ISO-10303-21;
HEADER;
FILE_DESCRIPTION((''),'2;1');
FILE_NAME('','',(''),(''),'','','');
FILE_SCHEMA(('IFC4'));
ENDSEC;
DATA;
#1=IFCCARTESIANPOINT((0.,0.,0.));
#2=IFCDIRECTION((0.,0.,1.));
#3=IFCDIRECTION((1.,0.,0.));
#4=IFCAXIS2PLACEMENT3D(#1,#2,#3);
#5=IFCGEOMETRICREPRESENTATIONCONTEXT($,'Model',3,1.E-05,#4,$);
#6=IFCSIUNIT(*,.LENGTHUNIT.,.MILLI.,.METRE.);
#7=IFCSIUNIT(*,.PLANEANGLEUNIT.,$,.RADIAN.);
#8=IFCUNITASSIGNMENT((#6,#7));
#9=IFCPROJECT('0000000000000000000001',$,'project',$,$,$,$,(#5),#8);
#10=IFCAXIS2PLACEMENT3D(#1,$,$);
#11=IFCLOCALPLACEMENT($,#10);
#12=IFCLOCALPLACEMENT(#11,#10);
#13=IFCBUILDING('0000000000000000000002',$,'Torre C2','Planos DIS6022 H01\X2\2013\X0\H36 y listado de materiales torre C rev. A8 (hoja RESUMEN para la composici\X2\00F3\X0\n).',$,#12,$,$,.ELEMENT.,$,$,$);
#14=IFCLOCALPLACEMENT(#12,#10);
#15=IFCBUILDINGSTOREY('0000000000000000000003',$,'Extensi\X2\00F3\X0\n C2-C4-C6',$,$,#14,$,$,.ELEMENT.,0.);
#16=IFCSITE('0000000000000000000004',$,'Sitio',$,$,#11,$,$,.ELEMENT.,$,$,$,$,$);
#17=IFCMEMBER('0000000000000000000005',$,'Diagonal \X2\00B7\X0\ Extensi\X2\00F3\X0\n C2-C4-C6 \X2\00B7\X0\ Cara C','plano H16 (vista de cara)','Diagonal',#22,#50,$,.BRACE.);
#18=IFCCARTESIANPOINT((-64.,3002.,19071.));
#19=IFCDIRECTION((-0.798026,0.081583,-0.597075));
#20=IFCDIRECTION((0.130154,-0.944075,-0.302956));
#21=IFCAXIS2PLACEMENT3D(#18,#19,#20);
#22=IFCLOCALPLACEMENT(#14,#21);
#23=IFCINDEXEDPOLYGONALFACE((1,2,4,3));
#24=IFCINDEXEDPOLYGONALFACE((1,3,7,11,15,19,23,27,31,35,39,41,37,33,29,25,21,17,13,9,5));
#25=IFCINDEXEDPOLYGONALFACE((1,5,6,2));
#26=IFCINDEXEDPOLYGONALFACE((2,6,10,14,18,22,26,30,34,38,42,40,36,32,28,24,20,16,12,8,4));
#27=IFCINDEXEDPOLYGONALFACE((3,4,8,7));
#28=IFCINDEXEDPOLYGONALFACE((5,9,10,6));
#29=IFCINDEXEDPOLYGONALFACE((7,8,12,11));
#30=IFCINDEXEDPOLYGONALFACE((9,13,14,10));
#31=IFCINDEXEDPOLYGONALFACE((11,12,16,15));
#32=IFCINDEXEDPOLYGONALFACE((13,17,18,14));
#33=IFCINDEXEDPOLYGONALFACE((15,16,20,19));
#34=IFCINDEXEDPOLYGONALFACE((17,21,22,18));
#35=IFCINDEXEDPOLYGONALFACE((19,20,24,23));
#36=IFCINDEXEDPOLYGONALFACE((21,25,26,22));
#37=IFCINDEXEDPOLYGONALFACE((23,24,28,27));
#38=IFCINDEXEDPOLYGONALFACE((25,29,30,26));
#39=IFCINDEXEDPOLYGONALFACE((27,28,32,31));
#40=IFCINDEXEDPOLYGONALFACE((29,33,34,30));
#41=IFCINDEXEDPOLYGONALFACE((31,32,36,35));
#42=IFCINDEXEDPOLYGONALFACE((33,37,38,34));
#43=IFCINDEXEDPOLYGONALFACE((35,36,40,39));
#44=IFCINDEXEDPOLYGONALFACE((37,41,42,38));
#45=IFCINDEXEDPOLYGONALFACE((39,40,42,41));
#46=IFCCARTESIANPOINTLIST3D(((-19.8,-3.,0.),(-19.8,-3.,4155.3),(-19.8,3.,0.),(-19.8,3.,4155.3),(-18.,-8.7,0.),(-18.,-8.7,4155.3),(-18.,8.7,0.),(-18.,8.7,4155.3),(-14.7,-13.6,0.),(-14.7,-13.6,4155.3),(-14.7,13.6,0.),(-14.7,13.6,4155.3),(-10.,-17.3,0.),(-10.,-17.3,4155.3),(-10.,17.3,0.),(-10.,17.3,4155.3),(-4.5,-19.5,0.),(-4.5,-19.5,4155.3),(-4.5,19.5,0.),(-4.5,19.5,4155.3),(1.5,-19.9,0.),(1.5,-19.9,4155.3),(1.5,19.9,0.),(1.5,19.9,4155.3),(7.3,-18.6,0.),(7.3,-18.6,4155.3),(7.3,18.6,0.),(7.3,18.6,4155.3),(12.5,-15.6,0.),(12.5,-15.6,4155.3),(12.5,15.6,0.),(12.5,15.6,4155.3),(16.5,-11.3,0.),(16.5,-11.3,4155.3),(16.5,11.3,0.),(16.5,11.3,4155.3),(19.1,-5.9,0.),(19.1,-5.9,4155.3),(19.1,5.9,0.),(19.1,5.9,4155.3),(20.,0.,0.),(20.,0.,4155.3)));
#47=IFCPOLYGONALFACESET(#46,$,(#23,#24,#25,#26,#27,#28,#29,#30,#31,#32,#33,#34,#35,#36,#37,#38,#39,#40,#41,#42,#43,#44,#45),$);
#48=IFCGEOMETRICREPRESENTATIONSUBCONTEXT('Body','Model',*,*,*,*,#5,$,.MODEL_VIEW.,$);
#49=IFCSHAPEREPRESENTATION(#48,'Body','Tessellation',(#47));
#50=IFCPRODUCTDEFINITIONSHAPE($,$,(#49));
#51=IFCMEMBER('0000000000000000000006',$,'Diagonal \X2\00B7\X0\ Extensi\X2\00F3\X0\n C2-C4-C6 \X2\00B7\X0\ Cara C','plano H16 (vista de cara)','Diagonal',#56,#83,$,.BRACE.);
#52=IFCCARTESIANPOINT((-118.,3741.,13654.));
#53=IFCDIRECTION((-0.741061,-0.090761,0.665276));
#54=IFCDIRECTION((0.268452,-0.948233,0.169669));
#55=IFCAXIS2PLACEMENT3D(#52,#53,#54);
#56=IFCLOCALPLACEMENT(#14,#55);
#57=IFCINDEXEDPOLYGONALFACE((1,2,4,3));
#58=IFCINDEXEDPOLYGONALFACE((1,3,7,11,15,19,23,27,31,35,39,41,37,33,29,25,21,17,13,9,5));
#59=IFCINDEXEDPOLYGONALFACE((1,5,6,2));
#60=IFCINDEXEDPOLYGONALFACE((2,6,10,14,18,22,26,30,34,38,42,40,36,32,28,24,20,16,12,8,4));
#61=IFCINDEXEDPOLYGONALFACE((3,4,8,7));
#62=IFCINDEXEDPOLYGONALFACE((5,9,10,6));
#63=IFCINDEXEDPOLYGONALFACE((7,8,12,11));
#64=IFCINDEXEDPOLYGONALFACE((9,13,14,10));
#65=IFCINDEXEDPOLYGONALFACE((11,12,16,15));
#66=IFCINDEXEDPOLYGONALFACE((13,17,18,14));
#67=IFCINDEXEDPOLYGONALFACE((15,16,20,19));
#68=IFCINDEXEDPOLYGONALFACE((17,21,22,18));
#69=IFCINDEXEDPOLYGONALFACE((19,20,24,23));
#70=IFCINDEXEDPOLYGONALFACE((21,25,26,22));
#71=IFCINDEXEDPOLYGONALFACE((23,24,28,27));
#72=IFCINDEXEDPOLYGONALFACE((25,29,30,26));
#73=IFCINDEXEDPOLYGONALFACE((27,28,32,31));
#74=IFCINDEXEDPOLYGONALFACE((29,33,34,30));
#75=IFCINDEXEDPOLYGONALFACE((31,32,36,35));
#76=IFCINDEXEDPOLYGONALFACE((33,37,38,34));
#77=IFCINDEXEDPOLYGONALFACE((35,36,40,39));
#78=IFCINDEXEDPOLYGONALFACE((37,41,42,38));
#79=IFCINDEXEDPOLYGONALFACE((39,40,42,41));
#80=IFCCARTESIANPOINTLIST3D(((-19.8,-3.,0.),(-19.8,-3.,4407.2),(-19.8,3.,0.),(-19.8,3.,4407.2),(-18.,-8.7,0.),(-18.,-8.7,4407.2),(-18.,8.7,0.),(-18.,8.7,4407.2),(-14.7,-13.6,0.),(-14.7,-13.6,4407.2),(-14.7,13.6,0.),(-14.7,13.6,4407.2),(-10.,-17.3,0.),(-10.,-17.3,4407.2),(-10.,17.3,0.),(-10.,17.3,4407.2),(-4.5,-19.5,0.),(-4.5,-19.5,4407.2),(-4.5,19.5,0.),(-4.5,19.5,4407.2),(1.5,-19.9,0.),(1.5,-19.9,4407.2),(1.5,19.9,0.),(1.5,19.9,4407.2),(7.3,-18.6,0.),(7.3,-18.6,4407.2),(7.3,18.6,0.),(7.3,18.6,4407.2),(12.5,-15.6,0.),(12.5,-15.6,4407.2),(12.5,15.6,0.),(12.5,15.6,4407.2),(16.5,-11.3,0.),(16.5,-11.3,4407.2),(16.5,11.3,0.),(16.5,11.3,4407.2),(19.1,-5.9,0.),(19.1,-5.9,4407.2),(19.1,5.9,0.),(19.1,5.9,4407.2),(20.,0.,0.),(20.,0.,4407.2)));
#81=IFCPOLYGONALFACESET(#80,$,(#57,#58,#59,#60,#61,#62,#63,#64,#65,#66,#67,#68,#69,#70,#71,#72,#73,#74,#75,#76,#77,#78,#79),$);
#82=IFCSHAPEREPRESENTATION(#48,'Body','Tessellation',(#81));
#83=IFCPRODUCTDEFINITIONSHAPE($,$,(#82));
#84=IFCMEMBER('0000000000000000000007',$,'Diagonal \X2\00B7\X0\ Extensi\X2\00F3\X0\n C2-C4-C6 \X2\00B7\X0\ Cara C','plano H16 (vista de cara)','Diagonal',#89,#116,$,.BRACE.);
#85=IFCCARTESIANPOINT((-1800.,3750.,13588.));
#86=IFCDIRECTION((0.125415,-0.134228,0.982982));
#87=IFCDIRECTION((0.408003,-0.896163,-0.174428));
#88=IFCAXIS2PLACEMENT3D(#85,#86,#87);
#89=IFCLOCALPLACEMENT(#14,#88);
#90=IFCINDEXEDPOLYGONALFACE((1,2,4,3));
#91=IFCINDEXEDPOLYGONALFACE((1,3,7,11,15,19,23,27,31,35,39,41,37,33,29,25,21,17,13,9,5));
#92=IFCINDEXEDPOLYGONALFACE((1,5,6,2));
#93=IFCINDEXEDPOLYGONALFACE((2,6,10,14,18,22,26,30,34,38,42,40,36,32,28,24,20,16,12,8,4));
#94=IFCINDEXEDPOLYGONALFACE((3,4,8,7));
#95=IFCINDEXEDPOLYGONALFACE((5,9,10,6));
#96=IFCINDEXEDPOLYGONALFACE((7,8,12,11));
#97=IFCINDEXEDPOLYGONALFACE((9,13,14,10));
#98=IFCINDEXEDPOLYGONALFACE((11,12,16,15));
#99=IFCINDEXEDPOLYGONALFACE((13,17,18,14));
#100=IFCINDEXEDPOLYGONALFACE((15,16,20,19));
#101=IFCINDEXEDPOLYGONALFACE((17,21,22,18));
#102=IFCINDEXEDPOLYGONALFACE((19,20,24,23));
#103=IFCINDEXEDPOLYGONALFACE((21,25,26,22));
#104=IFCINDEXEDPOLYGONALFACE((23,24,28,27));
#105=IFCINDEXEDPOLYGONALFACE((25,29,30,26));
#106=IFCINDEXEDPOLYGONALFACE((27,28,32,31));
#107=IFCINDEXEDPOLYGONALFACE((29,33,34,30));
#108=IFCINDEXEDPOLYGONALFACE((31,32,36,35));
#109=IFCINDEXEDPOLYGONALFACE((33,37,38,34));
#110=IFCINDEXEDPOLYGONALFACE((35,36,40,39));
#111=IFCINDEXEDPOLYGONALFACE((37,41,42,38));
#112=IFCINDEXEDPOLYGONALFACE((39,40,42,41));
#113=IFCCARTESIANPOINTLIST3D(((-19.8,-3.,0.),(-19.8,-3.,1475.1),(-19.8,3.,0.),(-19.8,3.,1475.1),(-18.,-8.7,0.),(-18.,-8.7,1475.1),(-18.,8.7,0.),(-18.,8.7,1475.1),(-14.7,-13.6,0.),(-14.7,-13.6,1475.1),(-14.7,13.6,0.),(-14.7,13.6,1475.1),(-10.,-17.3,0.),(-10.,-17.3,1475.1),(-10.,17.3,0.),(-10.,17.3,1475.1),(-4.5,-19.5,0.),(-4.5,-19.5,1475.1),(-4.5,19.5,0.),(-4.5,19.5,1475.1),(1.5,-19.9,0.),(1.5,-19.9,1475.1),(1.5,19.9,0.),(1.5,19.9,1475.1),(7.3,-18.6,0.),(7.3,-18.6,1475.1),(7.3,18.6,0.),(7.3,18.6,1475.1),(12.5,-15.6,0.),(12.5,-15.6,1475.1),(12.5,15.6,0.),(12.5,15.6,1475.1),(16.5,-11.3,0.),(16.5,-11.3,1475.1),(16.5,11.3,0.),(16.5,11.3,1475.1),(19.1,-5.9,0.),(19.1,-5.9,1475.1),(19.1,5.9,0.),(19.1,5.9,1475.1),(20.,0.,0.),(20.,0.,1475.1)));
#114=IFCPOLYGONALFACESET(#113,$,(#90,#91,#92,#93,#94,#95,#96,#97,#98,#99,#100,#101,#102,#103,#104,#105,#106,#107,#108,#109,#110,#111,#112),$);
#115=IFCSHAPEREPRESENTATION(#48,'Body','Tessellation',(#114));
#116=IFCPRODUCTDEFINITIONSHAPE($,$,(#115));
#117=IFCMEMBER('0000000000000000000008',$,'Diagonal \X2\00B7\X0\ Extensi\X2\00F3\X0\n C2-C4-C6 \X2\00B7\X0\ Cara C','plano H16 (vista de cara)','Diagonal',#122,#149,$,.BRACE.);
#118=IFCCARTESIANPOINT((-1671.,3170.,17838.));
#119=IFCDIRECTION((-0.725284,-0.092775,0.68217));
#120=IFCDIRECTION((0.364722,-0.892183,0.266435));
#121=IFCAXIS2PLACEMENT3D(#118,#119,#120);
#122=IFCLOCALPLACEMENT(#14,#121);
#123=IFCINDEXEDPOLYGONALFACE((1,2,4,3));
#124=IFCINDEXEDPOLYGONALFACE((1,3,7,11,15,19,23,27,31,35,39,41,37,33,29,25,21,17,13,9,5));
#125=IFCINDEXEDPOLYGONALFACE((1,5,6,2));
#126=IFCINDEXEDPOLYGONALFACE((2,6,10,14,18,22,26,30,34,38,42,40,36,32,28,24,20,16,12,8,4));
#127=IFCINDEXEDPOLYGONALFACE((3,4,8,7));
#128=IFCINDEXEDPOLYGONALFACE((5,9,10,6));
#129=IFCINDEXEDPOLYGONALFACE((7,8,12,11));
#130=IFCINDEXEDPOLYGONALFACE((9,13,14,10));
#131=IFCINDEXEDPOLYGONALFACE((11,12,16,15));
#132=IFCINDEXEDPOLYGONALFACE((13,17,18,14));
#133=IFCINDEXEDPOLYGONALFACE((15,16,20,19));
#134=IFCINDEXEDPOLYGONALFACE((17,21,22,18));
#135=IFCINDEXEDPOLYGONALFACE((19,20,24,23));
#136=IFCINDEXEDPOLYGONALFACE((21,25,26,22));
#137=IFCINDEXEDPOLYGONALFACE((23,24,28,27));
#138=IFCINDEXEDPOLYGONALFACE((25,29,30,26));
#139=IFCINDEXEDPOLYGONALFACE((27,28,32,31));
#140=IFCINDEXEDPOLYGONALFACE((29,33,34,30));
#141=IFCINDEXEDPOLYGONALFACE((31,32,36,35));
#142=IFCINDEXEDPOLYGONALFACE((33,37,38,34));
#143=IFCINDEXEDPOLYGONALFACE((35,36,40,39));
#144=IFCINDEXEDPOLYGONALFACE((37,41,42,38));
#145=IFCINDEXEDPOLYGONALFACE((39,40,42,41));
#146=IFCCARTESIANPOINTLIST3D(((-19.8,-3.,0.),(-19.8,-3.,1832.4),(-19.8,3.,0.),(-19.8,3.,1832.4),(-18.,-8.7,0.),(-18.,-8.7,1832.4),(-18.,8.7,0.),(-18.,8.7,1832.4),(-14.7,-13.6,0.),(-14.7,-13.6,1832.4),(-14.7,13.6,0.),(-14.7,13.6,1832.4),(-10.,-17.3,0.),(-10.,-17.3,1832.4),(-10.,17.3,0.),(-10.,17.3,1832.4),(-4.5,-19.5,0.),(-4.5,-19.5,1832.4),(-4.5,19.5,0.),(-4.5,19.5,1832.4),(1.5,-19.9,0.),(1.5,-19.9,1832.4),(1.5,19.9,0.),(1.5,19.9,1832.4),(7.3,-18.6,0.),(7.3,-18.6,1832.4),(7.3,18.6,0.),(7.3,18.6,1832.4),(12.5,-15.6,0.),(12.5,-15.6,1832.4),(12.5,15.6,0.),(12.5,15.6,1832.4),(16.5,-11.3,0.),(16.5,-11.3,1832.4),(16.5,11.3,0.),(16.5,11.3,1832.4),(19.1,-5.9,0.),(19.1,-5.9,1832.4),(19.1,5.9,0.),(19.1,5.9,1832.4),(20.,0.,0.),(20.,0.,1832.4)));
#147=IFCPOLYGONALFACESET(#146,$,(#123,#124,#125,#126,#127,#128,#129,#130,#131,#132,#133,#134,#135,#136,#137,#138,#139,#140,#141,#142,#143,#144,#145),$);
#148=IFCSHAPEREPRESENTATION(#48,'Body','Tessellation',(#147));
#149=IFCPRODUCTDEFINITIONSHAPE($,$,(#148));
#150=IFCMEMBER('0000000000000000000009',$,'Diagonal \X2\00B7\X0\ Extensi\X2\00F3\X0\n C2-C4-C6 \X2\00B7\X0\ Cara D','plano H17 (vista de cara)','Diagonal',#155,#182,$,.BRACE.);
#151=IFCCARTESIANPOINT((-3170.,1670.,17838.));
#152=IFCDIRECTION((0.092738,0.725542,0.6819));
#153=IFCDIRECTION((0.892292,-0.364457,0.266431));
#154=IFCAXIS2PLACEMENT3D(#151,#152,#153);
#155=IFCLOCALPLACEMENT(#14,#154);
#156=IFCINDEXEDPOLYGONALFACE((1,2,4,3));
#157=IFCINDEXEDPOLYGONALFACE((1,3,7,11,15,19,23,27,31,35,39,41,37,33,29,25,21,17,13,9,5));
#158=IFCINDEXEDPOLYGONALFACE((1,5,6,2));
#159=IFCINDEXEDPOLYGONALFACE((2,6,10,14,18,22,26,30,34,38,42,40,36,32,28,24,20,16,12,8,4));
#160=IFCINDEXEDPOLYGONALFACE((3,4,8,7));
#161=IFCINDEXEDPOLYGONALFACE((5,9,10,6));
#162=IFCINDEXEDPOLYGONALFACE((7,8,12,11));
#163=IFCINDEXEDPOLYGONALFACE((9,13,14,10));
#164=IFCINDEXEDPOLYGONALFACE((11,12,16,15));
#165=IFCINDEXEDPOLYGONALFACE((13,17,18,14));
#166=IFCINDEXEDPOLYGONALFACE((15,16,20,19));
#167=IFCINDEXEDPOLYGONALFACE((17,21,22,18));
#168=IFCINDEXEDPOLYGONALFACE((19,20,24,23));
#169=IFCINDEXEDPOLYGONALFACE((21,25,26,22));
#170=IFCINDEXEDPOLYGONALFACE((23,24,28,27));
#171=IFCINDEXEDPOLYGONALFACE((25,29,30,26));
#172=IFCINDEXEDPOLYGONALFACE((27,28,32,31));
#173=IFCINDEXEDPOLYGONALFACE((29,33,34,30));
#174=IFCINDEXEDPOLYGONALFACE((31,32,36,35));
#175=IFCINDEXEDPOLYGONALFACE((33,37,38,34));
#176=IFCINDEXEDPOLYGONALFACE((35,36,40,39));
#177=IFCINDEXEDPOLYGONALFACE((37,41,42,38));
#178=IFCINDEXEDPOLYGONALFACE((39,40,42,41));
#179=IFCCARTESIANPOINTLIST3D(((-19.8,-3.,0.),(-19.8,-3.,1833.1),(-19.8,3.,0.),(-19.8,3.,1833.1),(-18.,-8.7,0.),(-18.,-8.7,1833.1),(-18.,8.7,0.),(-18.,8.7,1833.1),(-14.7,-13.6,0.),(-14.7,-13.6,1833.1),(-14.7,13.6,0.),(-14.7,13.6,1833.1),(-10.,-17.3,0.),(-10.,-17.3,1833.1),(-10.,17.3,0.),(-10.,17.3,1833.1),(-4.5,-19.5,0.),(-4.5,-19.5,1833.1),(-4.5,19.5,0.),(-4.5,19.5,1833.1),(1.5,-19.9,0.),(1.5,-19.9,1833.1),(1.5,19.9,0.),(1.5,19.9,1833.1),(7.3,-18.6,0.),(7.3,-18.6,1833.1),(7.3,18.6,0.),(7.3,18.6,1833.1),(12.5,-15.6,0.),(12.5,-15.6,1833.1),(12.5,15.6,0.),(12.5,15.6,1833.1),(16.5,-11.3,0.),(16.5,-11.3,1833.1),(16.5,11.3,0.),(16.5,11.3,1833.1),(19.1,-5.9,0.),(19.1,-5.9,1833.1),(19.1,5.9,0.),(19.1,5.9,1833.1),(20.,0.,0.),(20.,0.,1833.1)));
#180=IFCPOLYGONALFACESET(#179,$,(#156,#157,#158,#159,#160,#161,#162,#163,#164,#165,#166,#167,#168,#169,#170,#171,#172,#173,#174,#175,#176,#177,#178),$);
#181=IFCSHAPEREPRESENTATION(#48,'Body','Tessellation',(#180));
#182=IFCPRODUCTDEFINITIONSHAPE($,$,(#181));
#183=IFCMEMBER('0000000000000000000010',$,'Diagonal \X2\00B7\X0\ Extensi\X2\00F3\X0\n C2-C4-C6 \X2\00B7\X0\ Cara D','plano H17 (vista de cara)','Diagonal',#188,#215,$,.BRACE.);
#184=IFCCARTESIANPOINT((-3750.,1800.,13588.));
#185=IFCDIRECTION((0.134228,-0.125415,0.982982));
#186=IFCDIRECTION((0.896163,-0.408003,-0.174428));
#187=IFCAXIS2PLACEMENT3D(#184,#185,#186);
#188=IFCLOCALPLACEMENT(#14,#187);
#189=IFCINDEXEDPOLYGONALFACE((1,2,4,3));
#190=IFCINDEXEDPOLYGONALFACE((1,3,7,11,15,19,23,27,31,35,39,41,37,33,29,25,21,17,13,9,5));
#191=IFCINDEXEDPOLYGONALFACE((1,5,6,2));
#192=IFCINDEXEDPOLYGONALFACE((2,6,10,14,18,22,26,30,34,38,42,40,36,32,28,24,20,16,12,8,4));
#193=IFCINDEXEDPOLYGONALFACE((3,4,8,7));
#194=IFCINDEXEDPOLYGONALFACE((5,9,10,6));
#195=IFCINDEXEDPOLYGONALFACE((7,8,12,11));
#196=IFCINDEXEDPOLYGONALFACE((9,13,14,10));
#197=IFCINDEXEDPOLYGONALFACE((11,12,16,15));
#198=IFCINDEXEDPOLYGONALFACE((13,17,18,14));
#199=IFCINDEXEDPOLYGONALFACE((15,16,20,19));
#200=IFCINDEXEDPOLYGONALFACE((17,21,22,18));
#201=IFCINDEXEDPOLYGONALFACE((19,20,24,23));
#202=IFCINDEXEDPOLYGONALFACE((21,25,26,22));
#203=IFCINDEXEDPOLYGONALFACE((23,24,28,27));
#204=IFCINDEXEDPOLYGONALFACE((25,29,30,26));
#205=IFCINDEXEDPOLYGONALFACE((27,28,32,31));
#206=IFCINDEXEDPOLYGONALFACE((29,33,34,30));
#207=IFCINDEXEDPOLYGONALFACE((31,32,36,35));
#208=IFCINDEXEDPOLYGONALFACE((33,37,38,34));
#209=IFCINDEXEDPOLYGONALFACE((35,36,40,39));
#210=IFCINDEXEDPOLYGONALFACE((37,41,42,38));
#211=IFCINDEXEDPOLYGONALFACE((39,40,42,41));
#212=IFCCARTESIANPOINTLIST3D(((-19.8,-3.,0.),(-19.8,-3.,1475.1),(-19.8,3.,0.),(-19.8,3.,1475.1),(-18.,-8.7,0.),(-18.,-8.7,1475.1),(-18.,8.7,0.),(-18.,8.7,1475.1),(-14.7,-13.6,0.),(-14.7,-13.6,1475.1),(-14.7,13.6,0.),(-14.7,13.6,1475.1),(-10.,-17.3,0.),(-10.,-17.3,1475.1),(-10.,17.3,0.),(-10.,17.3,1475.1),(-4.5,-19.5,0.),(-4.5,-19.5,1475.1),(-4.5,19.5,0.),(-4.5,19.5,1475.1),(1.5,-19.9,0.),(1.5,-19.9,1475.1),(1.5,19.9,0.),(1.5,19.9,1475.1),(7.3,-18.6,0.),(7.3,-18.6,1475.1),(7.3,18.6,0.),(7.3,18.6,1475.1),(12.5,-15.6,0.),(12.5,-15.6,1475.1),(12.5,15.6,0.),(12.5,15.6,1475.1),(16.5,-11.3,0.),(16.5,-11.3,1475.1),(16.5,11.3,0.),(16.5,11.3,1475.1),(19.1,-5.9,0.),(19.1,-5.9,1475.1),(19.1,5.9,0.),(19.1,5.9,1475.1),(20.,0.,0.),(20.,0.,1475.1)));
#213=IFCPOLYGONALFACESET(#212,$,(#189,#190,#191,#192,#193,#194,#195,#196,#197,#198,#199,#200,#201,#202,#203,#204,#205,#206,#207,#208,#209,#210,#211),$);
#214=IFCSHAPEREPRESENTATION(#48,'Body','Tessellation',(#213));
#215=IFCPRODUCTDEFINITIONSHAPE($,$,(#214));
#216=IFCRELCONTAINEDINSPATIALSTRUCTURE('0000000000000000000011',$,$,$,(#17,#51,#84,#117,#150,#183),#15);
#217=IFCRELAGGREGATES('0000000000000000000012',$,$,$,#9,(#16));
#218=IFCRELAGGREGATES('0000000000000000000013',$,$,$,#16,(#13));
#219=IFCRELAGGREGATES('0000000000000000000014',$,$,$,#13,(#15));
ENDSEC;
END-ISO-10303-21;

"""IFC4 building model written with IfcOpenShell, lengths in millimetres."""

from ifc_helpers import new_model, si_unit, frame, origin, origin_with_axes, place, context, subcontext, project, spatial, circle, extrude, element, save


model = new_model("IFC4")

# Units and contexts
model_context = context("Model", 3, precision=1e-05, world=origin_with_axes())
body_context = subcontext(model_context, "Body", "Model", "MODEL_VIEW")
ifc_project = project(units=[si_unit("LENGTHUNIT", "METRE", prefix="MILLI"), si_unit("PLANEANGLEUNIT", "RADIAN")], contexts=[model_context])

# Site, building, storey
site_placement = place(None, origin())
site = spatial("IfcSite", under=ifc_project, at=site_placement, Name="Sitio", CompositionType="ELEMENT")
building_placement = place(site_placement, origin())
building = spatial("IfcBuilding", under=site, at=building_placement, Name="Torre C2", Description="Planos DIS6022 H01–H36 y listado de materiales torre C rev. A8 (hoja RESUMEN para la composición).", CompositionType="ELEMENT")
storey_placement = place(building_placement, origin())
storey = spatial("IfcBuildingStorey", under=building, at=storey_placement, Name="Extensión C2-C4-C6", CompositionType="ELEMENT", Elevation=0.0)

# Members
member_1_placement = place(storey_placement, frame((-64.0, 3002.0, 19071.0), z_axis=(-0.798026, 0.081583, -0.597075), x_axis=(0.130154, -0.944075, -0.302956)))
element("IfcMember", 1, at=member_1_placement, inside=storey, Name="Diagonal · Extensión C2-C4-C6 · Cara C", Description="plano H16 (vista de cara)", ObjectType="Diagonal", PredefinedType="BRACE", context=body_context, shape_type="SweptSolid", body=[
    extrude(circle(Radius=20.0), None, (0.0, 0.0, 1.0), 4155.3),
])
member_2_placement = place(storey_placement, frame((-118.0, 3741.0, 13654.0), z_axis=(-0.741061, -0.090761, 0.665276), x_axis=(0.268452, -0.948233, 0.169669)))
element("IfcMember", 2, at=member_2_placement, inside=storey, Name="Diagonal · Extensión C2-C4-C6 · Cara C", Description="plano H16 (vista de cara)", ObjectType="Diagonal", PredefinedType="BRACE", context=body_context, shape_type="SweptSolid", body=[
    extrude(circle(Radius=20.0), None, (0.0, 0.0, 1.0), 4407.2),
])
member_3_placement = place(storey_placement, frame((-1800.0, 3750.0, 13588.0), z_axis=(0.125415, -0.134228, 0.982982), x_axis=(0.408003, -0.896163, -0.174428)))
element("IfcMember", 3, at=member_3_placement, inside=storey, Name="Diagonal · Extensión C2-C4-C6 · Cara C", Description="plano H16 (vista de cara)", ObjectType="Diagonal", PredefinedType="BRACE", context=body_context, shape_type="SweptSolid", body=[
    extrude(circle(Radius=20.0), None, (0.0, 0.0, 1.0), 1475.1),
])
member_4_placement = place(storey_placement, frame((-1671.0, 3170.0, 17838.0), z_axis=(-0.725284, -0.092775, 0.68217), x_axis=(0.364722, -0.892183, 0.266435)))
element("IfcMember", 4, at=member_4_placement, inside=storey, Name="Diagonal · Extensión C2-C4-C6 · Cara C", Description="plano H16 (vista de cara)", ObjectType="Diagonal", PredefinedType="BRACE", context=body_context, shape_type="SweptSolid", body=[
    extrude(circle(Radius=20.0), None, (0.0, 0.0, 1.0), 1832.4),
])
member_5_placement = place(storey_placement, frame((-3170.0, 1670.0, 17838.0), z_axis=(0.092738, 0.725542, 0.6819), x_axis=(0.892292, -0.364457, 0.266431)))
element("IfcMember", 5, at=member_5_placement, inside=storey, Name="Diagonal · Extensión C2-C4-C6 · Cara D", Description="plano H17 (vista de cara)", ObjectType="Diagonal", PredefinedType="BRACE", context=body_context, shape_type="SweptSolid", body=[
    extrude(circle(Radius=20.0), None, (0.0, 0.0, 1.0), 1833.1),
])
member_6_placement = place(storey_placement, frame((-3750.0, 1800.0, 13588.0), z_axis=(0.134228, -0.125415, 0.982982), x_axis=(0.896163, -0.408003, -0.174428)))
element("IfcMember", 6, at=member_6_placement, inside=storey, Name="Diagonal · Extensión C2-C4-C6 · Cara D", Description="plano H17 (vista de cara)", ObjectType="Diagonal", PredefinedType="BRACE", context=body_context, shape_type="SweptSolid", body=[
    extrude(circle(Radius=20.0), None, (0.0, 0.0, 1.0), 1475.1),
])

save(model, "model.ifc")
